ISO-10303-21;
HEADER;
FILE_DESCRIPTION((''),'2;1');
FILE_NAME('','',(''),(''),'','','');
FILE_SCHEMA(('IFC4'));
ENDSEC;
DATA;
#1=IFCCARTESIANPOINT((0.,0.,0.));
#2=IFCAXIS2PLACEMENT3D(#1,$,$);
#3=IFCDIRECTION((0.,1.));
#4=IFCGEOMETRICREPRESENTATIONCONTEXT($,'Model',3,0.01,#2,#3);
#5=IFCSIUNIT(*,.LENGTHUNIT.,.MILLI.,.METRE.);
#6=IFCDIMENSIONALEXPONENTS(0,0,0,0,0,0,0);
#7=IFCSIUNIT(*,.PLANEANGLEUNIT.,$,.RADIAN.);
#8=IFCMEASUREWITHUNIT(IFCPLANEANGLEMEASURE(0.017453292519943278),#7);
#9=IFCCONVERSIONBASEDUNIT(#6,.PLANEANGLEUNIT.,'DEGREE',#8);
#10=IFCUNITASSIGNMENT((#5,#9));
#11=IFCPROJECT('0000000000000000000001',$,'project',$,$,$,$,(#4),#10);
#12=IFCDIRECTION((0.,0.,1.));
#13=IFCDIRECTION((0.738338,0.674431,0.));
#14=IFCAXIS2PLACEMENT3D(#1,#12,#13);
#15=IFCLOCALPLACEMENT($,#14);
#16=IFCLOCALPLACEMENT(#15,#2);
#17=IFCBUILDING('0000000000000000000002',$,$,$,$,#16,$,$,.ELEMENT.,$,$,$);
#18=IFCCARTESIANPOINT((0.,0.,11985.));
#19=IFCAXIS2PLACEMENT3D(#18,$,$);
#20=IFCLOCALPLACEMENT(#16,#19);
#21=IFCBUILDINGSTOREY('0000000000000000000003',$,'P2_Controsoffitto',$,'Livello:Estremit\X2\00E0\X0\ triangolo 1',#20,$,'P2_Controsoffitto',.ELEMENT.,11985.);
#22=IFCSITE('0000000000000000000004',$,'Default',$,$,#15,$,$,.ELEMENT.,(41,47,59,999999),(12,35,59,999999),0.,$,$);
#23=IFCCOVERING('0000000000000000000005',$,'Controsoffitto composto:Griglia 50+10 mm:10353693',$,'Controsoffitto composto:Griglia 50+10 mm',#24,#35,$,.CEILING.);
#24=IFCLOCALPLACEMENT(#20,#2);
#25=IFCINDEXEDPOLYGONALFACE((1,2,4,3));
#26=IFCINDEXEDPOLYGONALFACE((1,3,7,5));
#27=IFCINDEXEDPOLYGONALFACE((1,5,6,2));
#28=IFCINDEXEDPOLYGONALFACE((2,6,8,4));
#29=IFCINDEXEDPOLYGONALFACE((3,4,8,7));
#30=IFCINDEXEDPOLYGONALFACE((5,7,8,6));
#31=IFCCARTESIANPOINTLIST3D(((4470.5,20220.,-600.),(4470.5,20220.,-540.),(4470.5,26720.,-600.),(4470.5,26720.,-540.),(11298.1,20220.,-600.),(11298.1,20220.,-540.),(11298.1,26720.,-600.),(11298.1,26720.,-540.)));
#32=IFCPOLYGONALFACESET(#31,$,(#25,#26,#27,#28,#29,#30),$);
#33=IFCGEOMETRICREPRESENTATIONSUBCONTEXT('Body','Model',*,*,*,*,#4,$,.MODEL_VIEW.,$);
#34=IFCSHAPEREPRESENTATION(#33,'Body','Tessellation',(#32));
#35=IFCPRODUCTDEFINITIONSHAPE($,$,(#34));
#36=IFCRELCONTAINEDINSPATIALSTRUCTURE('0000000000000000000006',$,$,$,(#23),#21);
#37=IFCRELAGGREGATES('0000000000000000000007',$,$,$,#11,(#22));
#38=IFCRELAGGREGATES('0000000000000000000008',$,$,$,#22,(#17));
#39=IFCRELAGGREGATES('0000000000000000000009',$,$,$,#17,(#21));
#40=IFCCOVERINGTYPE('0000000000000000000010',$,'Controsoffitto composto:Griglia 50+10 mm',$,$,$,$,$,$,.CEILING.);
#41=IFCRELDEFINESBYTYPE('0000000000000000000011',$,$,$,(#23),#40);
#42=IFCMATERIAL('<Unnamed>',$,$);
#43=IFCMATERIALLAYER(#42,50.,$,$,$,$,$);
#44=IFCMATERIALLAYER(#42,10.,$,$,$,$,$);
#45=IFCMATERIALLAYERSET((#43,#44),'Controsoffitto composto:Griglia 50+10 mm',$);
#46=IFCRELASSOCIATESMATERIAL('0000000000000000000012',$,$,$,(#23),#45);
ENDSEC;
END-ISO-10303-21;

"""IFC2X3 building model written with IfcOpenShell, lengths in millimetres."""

from ifc_helpers import new_model, entity, si_unit, converted_unit, direction, frame, frame_2d, origin, place, context, subcontext, project, spatial, rectangle, extrude, material, layer, layer_set, layer_usage, type_object, element, save


model = new_model("IFC2X3")

# Units and contexts
model_context = context("Model", 3, precision=0.01, world=origin(), true_north=direction((0.0, 1.0)))
body_context = subcontext(model_context, "Body", "Model", "MODEL_VIEW")
ifc_project = project(units=[si_unit("LENGTHUNIT", "METRE", prefix="MILLI"), converted_unit("PLANEANGLEUNIT", "DEGREE", entity("IfcPlaneAngleMeasure", 0.017453292519943278), si_unit("PLANEANGLEUNIT", "RADIAN"), dimensions=[0, 0, 0, 0, 0, 0, 0])], contexts=[model_context])

# Site, building, storey
site_placement = place(None, frame((0.0, 0.0, 0.0), z_axis=(0.0, 0.0, 1.0), x_axis=(0.738338, 0.674431, 0.0)))
site = spatial("IfcSite", under=ifc_project, at=site_placement, Name="Default", CompositionType="ELEMENT", RefLatitude=(41, 47, 59, 999999), RefLongitude=(12, 35, 59, 999999), RefElevation=0.0)
building_placement = place(site_placement, origin())
building = spatial("IfcBuilding", under=site, at=building_placement, CompositionType="ELEMENT")
storey_placement = place(building_placement, frame((0.0, 0.0, 11985.0)))
storey = spatial("IfcBuildingStorey", under=building, at=storey_placement, Name="P2_Controsoffitto", ObjectType="Livello:Estremità triangolo 1", LongName="P2_Controsoffitto", CompositionType="ELEMENT", Elevation=11985.0)

# Covering
ifc_material = material(Name="<Unnamed>")
ifc_layer_1 = layer(ifc_material, 50.0)
ifc_layer_2 = layer(ifc_material, 10.0)
ifc_layer_set = layer_set([ifc_layer_1, ifc_layer_2], Name="Controsoffitto composto:Griglia 50+10 mm")
ifc_layer_usage_1 = layer_usage(ifc_layer_set, "AXIS3", "NEGATIVE", 60.0)
covering_type = type_object("IfcCoveringType", Name="Controsoffitto composto:Griglia 50+10 mm", PredefinedType="CEILING")
covering_1_placement = place(storey_placement, origin())
element("IfcCovering", 1, at=covering_1_placement, inside=storey, type_object=covering_type, material=ifc_layer_usage_1, Name="Controsoffitto composto:Griglia 50+10 mm:10353693", ObjectType="Controsoffitto composto:Griglia 50+10 mm", PredefinedType="CEILING", context=body_context, shape_type="SweptSolid", body=[
    extrude(rectangle(XDim=6827.6, YDim=6500.0, at=frame_2d((0.0, 0.0), x_axis=(1.0, 0.0))), frame((7884.3, 23470.0, -600.0)), (0.0, 0.0, 1.0), 60.0),
])

save(model, "model.ifc")
